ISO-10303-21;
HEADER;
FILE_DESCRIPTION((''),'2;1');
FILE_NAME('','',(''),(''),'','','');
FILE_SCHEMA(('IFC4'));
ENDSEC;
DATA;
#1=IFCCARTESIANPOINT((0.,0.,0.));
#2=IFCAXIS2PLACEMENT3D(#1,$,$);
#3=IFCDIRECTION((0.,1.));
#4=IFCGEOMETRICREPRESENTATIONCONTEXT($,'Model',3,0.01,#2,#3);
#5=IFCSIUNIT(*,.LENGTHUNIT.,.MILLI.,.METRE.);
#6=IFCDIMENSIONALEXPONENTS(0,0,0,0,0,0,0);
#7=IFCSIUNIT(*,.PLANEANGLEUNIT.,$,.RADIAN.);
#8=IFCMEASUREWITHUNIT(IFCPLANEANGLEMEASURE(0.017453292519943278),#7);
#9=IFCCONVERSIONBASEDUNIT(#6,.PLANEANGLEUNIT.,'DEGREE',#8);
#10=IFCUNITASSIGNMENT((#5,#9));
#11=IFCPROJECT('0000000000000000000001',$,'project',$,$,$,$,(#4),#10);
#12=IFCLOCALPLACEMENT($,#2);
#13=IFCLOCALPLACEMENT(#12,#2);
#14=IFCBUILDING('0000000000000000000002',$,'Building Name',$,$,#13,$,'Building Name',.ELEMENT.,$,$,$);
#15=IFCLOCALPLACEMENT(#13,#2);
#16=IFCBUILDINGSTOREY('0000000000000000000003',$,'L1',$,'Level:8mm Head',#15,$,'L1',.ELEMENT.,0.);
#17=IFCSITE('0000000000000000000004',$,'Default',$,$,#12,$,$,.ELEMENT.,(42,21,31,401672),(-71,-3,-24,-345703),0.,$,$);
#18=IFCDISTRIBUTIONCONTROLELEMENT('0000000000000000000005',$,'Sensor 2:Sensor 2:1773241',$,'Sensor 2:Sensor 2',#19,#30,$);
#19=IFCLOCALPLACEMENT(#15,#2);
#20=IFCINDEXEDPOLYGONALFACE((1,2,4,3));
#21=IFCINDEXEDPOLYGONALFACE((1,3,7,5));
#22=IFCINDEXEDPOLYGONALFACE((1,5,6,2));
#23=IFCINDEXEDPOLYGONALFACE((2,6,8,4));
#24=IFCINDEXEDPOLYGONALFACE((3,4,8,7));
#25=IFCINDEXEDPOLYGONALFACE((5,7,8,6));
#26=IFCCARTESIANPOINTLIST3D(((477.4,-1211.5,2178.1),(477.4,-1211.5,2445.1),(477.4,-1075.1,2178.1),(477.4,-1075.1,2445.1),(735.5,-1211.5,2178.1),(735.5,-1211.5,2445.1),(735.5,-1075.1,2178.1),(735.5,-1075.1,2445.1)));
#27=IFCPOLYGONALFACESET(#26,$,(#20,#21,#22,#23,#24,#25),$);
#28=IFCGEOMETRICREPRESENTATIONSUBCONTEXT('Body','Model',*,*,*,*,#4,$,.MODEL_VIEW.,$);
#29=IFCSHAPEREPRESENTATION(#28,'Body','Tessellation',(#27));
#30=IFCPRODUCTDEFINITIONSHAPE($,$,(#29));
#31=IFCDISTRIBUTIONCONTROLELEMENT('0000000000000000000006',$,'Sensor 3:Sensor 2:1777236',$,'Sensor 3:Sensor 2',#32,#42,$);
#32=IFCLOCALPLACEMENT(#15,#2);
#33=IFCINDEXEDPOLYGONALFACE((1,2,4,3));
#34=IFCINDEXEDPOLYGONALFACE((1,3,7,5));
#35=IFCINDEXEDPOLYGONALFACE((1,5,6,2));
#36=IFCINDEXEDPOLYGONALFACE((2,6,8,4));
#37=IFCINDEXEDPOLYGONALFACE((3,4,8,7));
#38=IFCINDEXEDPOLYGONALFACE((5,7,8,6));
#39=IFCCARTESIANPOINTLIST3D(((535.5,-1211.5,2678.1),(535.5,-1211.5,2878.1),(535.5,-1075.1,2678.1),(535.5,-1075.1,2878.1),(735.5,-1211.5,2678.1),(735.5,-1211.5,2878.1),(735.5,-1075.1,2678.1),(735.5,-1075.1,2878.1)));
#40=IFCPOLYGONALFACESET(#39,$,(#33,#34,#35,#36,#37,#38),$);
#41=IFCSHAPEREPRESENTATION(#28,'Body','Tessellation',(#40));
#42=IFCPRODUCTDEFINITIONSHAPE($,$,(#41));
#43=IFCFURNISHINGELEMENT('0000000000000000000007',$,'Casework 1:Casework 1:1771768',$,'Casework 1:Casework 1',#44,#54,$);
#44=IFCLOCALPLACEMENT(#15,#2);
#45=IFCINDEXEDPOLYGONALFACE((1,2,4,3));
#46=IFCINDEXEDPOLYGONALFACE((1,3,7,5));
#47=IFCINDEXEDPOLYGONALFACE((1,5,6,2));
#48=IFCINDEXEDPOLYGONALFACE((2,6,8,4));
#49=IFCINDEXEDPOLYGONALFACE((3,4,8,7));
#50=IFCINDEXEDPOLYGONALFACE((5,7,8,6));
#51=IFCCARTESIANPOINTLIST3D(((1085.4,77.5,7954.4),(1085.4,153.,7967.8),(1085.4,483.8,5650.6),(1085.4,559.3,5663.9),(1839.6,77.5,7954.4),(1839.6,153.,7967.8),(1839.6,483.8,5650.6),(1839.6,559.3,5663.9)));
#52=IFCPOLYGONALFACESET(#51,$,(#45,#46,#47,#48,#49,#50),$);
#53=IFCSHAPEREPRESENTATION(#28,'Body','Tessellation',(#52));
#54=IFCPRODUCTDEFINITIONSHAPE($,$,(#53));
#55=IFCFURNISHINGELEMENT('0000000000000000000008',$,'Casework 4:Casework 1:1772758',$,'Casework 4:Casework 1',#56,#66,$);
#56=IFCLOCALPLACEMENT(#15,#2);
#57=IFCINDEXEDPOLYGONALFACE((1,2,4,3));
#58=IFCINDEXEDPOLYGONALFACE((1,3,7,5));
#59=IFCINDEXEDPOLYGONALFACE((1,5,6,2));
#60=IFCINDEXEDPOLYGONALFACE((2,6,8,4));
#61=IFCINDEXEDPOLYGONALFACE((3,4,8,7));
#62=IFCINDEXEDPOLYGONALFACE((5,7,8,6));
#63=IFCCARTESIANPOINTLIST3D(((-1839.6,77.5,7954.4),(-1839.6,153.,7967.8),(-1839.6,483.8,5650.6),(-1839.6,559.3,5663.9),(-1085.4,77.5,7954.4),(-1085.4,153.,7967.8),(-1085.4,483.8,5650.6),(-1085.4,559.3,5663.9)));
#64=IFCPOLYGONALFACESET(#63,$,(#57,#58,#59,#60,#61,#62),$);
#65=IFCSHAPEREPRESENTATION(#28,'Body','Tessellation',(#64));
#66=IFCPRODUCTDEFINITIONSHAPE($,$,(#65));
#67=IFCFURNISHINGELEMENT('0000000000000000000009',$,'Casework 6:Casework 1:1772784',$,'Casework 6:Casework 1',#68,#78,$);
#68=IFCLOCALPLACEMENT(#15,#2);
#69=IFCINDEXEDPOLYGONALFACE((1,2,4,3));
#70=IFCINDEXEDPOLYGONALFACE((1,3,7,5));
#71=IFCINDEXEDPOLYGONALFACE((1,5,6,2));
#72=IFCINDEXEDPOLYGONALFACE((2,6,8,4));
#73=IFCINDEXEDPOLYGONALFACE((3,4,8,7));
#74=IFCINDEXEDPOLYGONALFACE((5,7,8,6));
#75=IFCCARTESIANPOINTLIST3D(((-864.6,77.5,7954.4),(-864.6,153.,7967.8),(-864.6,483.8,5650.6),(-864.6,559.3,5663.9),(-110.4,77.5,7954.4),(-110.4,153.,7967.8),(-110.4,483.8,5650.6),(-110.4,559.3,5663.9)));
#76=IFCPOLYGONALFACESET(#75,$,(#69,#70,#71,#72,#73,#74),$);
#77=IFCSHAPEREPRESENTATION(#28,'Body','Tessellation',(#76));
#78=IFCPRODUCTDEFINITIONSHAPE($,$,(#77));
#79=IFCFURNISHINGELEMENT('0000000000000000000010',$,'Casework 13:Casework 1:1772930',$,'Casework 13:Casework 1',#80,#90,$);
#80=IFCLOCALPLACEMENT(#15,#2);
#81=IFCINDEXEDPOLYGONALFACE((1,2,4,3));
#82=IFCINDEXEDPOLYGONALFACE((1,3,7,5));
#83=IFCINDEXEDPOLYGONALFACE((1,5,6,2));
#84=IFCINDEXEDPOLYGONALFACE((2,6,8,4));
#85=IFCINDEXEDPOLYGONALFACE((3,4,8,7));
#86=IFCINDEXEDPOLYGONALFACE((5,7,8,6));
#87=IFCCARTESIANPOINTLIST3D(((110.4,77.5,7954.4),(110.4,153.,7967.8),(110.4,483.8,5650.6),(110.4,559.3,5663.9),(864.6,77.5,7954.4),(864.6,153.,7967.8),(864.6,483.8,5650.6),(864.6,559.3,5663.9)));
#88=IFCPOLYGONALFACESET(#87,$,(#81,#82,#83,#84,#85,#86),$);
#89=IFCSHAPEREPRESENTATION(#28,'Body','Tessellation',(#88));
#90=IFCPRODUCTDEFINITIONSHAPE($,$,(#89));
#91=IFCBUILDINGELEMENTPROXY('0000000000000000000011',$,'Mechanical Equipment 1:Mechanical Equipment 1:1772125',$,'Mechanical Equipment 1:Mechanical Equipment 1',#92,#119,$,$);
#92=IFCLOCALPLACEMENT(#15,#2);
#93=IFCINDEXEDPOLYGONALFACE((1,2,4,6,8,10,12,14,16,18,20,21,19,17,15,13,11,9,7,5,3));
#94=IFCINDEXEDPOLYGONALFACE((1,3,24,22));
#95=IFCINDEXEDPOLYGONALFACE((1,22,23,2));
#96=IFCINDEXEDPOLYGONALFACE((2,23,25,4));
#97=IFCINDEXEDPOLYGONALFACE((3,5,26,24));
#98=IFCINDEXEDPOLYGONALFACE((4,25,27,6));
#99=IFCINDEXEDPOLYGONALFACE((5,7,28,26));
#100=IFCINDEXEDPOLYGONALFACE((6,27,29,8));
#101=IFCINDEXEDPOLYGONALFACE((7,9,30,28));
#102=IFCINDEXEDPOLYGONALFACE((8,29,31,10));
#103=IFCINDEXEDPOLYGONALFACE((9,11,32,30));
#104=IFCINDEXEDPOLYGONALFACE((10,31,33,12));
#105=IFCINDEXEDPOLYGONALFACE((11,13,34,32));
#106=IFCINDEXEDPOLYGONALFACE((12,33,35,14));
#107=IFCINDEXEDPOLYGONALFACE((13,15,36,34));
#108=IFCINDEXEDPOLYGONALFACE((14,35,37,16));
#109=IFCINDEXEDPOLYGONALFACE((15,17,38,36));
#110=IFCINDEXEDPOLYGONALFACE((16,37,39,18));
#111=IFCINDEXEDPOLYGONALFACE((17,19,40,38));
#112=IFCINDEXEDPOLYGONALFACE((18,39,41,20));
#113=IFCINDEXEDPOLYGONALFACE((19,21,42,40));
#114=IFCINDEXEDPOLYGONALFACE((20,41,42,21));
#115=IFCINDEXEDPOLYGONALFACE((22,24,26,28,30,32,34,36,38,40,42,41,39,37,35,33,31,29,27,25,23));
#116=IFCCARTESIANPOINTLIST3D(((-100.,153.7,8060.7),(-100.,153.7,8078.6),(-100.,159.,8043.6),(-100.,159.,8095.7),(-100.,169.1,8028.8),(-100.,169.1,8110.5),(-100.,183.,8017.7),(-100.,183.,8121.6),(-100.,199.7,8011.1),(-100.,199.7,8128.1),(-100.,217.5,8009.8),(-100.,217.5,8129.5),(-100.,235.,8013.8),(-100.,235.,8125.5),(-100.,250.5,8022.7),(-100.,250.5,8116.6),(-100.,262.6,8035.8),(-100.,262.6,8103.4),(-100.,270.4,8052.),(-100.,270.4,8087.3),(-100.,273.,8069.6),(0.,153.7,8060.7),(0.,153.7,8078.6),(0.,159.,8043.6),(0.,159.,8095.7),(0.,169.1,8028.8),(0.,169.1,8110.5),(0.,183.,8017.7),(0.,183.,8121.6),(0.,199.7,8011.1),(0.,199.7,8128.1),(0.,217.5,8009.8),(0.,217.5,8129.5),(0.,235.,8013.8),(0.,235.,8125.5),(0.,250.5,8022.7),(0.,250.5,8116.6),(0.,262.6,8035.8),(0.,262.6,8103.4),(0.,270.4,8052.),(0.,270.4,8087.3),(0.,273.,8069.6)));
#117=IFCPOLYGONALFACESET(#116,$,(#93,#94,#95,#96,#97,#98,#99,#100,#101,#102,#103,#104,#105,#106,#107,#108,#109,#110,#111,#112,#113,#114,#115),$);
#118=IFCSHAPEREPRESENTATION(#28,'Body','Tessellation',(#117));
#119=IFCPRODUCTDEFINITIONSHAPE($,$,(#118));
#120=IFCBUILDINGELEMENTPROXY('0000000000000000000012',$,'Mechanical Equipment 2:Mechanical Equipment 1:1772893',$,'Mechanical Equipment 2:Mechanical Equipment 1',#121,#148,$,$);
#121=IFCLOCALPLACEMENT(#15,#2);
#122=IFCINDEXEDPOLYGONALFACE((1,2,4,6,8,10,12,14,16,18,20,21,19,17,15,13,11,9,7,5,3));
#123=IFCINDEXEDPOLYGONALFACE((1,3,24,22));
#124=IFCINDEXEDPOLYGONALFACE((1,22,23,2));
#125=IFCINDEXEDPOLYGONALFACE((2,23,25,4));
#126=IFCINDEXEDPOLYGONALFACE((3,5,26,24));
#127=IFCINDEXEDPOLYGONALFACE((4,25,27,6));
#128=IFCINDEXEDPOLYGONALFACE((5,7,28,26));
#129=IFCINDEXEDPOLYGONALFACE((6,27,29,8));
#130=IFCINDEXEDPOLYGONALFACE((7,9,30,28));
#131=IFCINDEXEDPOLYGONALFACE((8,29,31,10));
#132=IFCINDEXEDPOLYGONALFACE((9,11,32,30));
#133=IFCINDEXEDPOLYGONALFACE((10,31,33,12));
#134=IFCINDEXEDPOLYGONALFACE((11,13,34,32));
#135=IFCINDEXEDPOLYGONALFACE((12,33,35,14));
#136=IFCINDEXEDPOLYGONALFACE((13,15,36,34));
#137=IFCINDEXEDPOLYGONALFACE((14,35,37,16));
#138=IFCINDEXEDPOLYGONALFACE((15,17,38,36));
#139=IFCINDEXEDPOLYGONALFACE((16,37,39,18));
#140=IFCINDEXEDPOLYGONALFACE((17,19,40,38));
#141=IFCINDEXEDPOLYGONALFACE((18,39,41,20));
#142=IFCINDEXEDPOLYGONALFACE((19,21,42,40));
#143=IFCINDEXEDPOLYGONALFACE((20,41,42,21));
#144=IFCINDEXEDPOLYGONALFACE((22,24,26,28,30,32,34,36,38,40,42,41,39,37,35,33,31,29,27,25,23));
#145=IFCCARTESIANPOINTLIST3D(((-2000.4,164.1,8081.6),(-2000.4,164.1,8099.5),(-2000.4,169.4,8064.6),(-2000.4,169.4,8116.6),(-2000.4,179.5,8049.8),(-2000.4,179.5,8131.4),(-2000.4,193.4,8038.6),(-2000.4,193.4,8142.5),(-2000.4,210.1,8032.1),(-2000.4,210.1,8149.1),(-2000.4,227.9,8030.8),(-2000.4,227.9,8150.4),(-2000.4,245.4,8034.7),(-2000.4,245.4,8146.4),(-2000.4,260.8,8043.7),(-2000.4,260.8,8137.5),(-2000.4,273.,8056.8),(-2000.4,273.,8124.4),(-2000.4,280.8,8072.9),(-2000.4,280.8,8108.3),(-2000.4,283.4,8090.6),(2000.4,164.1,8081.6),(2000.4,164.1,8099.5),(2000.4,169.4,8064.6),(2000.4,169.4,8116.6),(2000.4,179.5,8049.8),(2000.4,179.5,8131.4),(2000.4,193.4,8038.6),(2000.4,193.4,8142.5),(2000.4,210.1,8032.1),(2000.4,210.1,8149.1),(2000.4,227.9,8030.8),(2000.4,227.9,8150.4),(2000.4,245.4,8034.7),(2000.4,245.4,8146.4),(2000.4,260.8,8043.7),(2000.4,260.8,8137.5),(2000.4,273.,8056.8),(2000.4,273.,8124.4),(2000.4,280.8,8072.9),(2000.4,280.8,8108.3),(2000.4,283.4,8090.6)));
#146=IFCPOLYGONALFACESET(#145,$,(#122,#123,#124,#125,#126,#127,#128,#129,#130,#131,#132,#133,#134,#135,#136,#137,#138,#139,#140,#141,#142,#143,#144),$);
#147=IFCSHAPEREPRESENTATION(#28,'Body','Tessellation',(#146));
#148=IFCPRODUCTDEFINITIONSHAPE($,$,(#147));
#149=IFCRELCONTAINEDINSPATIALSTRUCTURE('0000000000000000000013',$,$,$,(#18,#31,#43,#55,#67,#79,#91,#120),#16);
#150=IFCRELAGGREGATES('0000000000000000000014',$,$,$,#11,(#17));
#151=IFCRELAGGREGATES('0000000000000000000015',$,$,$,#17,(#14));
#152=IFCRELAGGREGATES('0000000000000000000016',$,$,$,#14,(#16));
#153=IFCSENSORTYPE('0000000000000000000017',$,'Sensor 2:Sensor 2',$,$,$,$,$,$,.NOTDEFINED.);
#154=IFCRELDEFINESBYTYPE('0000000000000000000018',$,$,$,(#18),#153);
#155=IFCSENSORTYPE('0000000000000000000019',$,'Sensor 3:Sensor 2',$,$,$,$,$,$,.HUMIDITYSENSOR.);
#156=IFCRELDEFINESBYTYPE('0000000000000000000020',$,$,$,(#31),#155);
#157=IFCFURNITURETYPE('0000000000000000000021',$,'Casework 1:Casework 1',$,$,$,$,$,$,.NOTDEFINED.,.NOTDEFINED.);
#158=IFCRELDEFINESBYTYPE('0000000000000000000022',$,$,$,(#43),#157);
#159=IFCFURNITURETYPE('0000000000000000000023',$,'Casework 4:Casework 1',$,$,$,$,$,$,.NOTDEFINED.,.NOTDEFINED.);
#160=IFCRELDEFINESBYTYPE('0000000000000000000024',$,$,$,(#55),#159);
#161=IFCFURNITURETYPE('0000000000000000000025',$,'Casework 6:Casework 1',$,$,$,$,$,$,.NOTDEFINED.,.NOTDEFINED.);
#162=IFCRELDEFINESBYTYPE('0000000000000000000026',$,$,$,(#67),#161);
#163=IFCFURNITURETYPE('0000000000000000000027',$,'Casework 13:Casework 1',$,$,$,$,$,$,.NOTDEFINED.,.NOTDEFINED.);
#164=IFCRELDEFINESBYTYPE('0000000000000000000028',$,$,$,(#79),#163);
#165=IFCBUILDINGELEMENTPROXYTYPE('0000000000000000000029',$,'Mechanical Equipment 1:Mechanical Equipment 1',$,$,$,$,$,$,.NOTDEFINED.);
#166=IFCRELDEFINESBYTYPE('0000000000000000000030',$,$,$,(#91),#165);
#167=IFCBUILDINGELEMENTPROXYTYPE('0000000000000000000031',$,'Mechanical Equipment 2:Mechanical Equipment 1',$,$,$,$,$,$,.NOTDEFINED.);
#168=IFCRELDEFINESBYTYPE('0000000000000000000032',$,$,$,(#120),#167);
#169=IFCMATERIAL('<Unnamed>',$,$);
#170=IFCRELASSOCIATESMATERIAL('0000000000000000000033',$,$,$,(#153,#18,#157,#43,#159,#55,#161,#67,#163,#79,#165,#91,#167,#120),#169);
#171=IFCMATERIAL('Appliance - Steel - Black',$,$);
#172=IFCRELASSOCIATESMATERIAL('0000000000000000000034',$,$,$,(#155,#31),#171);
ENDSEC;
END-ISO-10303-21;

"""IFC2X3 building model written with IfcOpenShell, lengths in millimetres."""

from ifc_helpers import new_model, entity, si_unit, converted_unit, direction, frame, frame_2d, origin, origin_2d_with_axis, place, context, subcontext, project, spatial, rectangle, circle, extrude, source, transform, mapped, material, type_object, type_shapes, element, save


model = new_model("IFC2X3")

# Units and contexts
model_context = context("Model", 3, precision=0.01, world=origin(), true_north=direction((0.0, 1.0)))
body_context = subcontext(model_context, "Body", "Model", "MODEL_VIEW")
ifc_project = project(units=[si_unit("LENGTHUNIT", "METRE", prefix="MILLI"), converted_unit("PLANEANGLEUNIT", "DEGREE", entity("IfcPlaneAngleMeasure", 0.017453292519943278), si_unit("PLANEANGLEUNIT", "RADIAN"), dimensions=[0, 0, 0, 0, 0, 0, 0])], contexts=[model_context])

# Site, building, storey
site_placement = place(None, origin())
site = spatial("IfcSite", under=ifc_project, at=site_placement, Name="Default", CompositionType="ELEMENT", RefLatitude=(42, 21, 31, 401672), RefLongitude=(-71, -3, -24, -345703), RefElevation=0.0)
building_placement = place(site_placement, origin())
building = spatial("IfcBuilding", under=site, at=building_placement, Name="Building Name", LongName="Building Name", CompositionType="ELEMENT")
storey_placement = place(building_placement, origin())
storey = spatial("IfcBuildingStorey", under=building, at=storey_placement, Name="L1", ObjectType="Level:8mm Head", LongName="L1", CompositionType="ELEMENT", Elevation=0.0)

# Shared definitions
ifc_material_1 = material(Name="<Unnamed>")

# Distribution control elements
sensor_type_1 = type_object("IfcSensorType", Name="Sensor 2:Sensor 2", PredefinedType="NOTDEFINED", material=ifc_material_1)
shared_shape_1 = source(origin(), body_context, "Body", "SweptSolid", [
    extrude(rectangle(XDim=136.4, YDim=258.1, at=frame_2d((0.0, 0.0), x_axis=(1.0, 0.0))), frame((606.5, -1143.3, 2178.1), z_axis=(0.0, 0.0, 1.0), x_axis=(0.0, -1.0, 0.0)), (0.0, 0.0, 1.0), 267.0),
])
type_shapes(sensor_type_1, [shared_shape_1])
distribution_control_element_1_placement = place(storey_placement, origin())
element("IfcDistributionControlElement", 1, at=distribution_control_element_1_placement, inside=storey, type_object=sensor_type_1, material=ifc_material_1, Name="Sensor 2:Sensor 2:1773241", ObjectType="Sensor 2:Sensor 2", context=body_context, shape_type="MappedRepresentation", body=[
    mapped(shared_shape_1, transform((0.0, 0.0, 0.0), scale=1.0)),
])
ifc_material_2 = material(Name="Appliance - Steel - Black")
sensor_type_2 = type_object("IfcSensorType", Name="Sensor 3:Sensor 2", PredefinedType="HUMIDITYSENSOR", material=ifc_material_2)
shared_shape_2 = source(origin(), body_context, "Body", "SweptSolid", [
    extrude(rectangle(XDim=136.4, YDim=200.0, at=frame_2d((0.0, 0.0), x_axis=(1.0, 0.0))), frame((635.5, -1143.3, 2678.1), z_axis=(0.0, 0.0, 1.0), x_axis=(0.0, -1.0, 0.0)), (0.0, 0.0, 1.0), 200.0),
])
type_shapes(sensor_type_2, [shared_shape_2])
distribution_control_element_2_placement = place(storey_placement, origin())
element("IfcDistributionControlElement", 2, at=distribution_control_element_2_placement, inside=storey, type_object=sensor_type_2, material=ifc_material_2, Name="Sensor 3:Sensor 2:1777236", ObjectType="Sensor 3:Sensor 2", context=body_context, shape_type="MappedRepresentation", body=[
    mapped(shared_shape_2, transform((0.0, 0.0, 0.0), scale=1.0)),
])

# Furnishing elements
furniture_type_1 = type_object("IfcFurnitureType", Name="Casework 1:Casework 1", AssemblyPlace="NOTDEFINED", material=ifc_material_1)
shared_shape_3 = source(origin(), body_context, "Body", "SweptSolid", [
    extrude(rectangle(XDim=76.7, YDim=754.1, at=frame_2d((0.0, 0.0), x_axis=(1.0, 0.0))), frame((1462.5, 521.5, 5657.2), z_axis=(0.0, -0.173648, 0.984808), x_axis=(0.0, -0.984808, -0.173648)), (0.0, 0.0, 1.0), 2339.4),
])
type_shapes(furniture_type_1, [shared_shape_3])
furnishing_1_placement = place(storey_placement, origin())
element("IfcFurnishingElement", 3, at=furnishing_1_placement, inside=storey, type_object=furniture_type_1, material=ifc_material_1, Name="Casework 1:Casework 1:1771768", ObjectType="Casework 1:Casework 1", context=body_context, shape_type="MappedRepresentation", body=[
    mapped(shared_shape_3, transform((0.0, 0.0, 0.0), scale=1.0)),
])
furniture_type_2 = type_object("IfcFurnitureType", Name="Casework 4:Casework 1", AssemblyPlace="NOTDEFINED", material=ifc_material_1)
shared_shape_4 = source(origin(), body_context, "Body", "SweptSolid", [
    extrude(rectangle(XDim=76.7, YDim=754.1, at=frame_2d((0.0, 0.0), x_axis=(1.0, 0.0))), frame((-1462.5, 521.5, 5657.2), z_axis=(0.0, -0.173648, 0.984808), x_axis=(0.0, -0.984808, -0.173648)), (0.0, 0.0, 1.0), 2339.4),
])
type_shapes(furniture_type_2, [shared_shape_4])
furnishing_2_placement = place(storey_placement, origin())
element("IfcFurnishingElement", 4, at=furnishing_2_placement, inside=storey, type_object=furniture_type_2, material=ifc_material_1, Name="Casework 4:Casework 1:1772758", ObjectType="Casework 4:Casework 1", context=body_context, shape_type="MappedRepresentation", body=[
    mapped(shared_shape_4, transform((0.0, 0.0, 0.0), scale=1.0)),
])
furniture_type_3 = type_object("IfcFurnitureType", Name="Casework 6:Casework 1", AssemblyPlace="NOTDEFINED", material=ifc_material_1)
shared_shape_5 = source(origin(), body_context, "Body", "SweptSolid", [
    extrude(rectangle(XDim=76.7, YDim=754.1, at=frame_2d((0.0, 0.0), x_axis=(1.0, 0.0))), frame((-487.5, 521.5, 5657.2), z_axis=(0.0, -0.173648, 0.984808), x_axis=(0.0, -0.984808, -0.173648)), (0.0, 0.0, 1.0), 2339.4),
])
type_shapes(furniture_type_3, [shared_shape_5])
furnishing_3_placement = place(storey_placement, origin())
element("IfcFurnishingElement", 5, at=furnishing_3_placement, inside=storey, type_object=furniture_type_3, material=ifc_material_1, Name="Casework 6:Casework 1:1772784", ObjectType="Casework 6:Casework 1", context=body_context, shape_type="MappedRepresentation", body=[
    mapped(shared_shape_5, transform((0.0, 0.0, 0.0), scale=1.0)),
])
furniture_type_4 = type_object("IfcFurnitureType", Name="Casework 13:Casework 1", AssemblyPlace="NOTDEFINED", material=ifc_material_1)
shared_shape_6 = source(origin(), body_context, "Body", "SweptSolid", [
    extrude(rectangle(XDim=76.7, YDim=754.1, at=frame_2d((0.0, 0.0), x_axis=(1.0, 0.0))), frame((487.5, 521.5, 5657.2), z_axis=(0.0, -0.173648, 0.984808), x_axis=(0.0, -0.984808, -0.173648)), (0.0, 0.0, 1.0), 2339.4),
])
type_shapes(furniture_type_4, [shared_shape_6])
furnishing_4_placement = place(storey_placement, origin())
element("IfcFurnishingElement", 6, at=furnishing_4_placement, inside=storey, type_object=furniture_type_4, material=ifc_material_1, Name="Casework 13:Casework 1:1772930", ObjectType="Casework 13:Casework 1", context=body_context, shape_type="MappedRepresentation", body=[
    mapped(shared_shape_6, transform((0.0, 0.0, 0.0), scale=1.0)),
])

# Building element proxies
building_element_proxy_type_1 = type_object("IfcBuildingElementProxyType", Name="Mechanical Equipment 1:Mechanical Equipment 1", PredefinedType="NOTDEFINED", material=ifc_material_1)
shared_shape_7 = source(origin(), body_context, "Body", "SweptSolid", [
    extrude(circle(Radius=60.0, at=origin_2d_with_axis()), frame((-100.0, 213.0, 8069.6), z_axis=(1.0, 0.0, 0.0), x_axis=(0.0, 1.0, 0.0)), (0.0, 0.0, 1.0), 100.0),
])
type_shapes(building_element_proxy_type_1, [shared_shape_7])
proxy_1_placement = place(storey_placement, origin())
element("IfcBuildingElementProxy", 7, at=proxy_1_placement, inside=storey, type_object=building_element_proxy_type_1, material=ifc_material_1, Name="Mechanical Equipment 1:Mechanical Equipment 1:1772125", ObjectType="Mechanical Equipment 1:Mechanical Equipment 1", context=body_context, shape_type="MappedRepresentation", body=[
    mapped(shared_shape_7, transform((0.0, 0.0, 0.0), scale=1.0)),
])
building_element_proxy_type_2 = type_object("IfcBuildingElementProxyType", Name="Mechanical Equipment 2:Mechanical Equipment 1", PredefinedType="NOTDEFINED", material=ifc_material_1)
shared_shape_8 = source(origin(), body_context, "Body", "SweptSolid", [
    extrude(circle(Radius=60.0, at=origin_2d_with_axis()), frame((-2000.4, 223.4, 8090.6), z_axis=(1.0, 0.0, 0.0), x_axis=(0.0, 1.0, 0.0)), (0.0, 0.0, 1.0), 4000.9),
])
type_shapes(building_element_proxy_type_2, [shared_shape_8])
proxy_2_placement = place(storey_placement, origin())
element("IfcBuildingElementProxy", 8, at=proxy_2_placement, inside=storey, type_object=building_element_proxy_type_2, material=ifc_material_1, Name="Mechanical Equipment 2:Mechanical Equipment 1:1772893", ObjectType="Mechanical Equipment 2:Mechanical Equipment 1", context=body_context, shape_type="MappedRepresentation", body=[
    mapped(shared_shape_8, transform((0.0, 0.0, 0.0), scale=1.0)),
])

save(model, "model.ifc")
